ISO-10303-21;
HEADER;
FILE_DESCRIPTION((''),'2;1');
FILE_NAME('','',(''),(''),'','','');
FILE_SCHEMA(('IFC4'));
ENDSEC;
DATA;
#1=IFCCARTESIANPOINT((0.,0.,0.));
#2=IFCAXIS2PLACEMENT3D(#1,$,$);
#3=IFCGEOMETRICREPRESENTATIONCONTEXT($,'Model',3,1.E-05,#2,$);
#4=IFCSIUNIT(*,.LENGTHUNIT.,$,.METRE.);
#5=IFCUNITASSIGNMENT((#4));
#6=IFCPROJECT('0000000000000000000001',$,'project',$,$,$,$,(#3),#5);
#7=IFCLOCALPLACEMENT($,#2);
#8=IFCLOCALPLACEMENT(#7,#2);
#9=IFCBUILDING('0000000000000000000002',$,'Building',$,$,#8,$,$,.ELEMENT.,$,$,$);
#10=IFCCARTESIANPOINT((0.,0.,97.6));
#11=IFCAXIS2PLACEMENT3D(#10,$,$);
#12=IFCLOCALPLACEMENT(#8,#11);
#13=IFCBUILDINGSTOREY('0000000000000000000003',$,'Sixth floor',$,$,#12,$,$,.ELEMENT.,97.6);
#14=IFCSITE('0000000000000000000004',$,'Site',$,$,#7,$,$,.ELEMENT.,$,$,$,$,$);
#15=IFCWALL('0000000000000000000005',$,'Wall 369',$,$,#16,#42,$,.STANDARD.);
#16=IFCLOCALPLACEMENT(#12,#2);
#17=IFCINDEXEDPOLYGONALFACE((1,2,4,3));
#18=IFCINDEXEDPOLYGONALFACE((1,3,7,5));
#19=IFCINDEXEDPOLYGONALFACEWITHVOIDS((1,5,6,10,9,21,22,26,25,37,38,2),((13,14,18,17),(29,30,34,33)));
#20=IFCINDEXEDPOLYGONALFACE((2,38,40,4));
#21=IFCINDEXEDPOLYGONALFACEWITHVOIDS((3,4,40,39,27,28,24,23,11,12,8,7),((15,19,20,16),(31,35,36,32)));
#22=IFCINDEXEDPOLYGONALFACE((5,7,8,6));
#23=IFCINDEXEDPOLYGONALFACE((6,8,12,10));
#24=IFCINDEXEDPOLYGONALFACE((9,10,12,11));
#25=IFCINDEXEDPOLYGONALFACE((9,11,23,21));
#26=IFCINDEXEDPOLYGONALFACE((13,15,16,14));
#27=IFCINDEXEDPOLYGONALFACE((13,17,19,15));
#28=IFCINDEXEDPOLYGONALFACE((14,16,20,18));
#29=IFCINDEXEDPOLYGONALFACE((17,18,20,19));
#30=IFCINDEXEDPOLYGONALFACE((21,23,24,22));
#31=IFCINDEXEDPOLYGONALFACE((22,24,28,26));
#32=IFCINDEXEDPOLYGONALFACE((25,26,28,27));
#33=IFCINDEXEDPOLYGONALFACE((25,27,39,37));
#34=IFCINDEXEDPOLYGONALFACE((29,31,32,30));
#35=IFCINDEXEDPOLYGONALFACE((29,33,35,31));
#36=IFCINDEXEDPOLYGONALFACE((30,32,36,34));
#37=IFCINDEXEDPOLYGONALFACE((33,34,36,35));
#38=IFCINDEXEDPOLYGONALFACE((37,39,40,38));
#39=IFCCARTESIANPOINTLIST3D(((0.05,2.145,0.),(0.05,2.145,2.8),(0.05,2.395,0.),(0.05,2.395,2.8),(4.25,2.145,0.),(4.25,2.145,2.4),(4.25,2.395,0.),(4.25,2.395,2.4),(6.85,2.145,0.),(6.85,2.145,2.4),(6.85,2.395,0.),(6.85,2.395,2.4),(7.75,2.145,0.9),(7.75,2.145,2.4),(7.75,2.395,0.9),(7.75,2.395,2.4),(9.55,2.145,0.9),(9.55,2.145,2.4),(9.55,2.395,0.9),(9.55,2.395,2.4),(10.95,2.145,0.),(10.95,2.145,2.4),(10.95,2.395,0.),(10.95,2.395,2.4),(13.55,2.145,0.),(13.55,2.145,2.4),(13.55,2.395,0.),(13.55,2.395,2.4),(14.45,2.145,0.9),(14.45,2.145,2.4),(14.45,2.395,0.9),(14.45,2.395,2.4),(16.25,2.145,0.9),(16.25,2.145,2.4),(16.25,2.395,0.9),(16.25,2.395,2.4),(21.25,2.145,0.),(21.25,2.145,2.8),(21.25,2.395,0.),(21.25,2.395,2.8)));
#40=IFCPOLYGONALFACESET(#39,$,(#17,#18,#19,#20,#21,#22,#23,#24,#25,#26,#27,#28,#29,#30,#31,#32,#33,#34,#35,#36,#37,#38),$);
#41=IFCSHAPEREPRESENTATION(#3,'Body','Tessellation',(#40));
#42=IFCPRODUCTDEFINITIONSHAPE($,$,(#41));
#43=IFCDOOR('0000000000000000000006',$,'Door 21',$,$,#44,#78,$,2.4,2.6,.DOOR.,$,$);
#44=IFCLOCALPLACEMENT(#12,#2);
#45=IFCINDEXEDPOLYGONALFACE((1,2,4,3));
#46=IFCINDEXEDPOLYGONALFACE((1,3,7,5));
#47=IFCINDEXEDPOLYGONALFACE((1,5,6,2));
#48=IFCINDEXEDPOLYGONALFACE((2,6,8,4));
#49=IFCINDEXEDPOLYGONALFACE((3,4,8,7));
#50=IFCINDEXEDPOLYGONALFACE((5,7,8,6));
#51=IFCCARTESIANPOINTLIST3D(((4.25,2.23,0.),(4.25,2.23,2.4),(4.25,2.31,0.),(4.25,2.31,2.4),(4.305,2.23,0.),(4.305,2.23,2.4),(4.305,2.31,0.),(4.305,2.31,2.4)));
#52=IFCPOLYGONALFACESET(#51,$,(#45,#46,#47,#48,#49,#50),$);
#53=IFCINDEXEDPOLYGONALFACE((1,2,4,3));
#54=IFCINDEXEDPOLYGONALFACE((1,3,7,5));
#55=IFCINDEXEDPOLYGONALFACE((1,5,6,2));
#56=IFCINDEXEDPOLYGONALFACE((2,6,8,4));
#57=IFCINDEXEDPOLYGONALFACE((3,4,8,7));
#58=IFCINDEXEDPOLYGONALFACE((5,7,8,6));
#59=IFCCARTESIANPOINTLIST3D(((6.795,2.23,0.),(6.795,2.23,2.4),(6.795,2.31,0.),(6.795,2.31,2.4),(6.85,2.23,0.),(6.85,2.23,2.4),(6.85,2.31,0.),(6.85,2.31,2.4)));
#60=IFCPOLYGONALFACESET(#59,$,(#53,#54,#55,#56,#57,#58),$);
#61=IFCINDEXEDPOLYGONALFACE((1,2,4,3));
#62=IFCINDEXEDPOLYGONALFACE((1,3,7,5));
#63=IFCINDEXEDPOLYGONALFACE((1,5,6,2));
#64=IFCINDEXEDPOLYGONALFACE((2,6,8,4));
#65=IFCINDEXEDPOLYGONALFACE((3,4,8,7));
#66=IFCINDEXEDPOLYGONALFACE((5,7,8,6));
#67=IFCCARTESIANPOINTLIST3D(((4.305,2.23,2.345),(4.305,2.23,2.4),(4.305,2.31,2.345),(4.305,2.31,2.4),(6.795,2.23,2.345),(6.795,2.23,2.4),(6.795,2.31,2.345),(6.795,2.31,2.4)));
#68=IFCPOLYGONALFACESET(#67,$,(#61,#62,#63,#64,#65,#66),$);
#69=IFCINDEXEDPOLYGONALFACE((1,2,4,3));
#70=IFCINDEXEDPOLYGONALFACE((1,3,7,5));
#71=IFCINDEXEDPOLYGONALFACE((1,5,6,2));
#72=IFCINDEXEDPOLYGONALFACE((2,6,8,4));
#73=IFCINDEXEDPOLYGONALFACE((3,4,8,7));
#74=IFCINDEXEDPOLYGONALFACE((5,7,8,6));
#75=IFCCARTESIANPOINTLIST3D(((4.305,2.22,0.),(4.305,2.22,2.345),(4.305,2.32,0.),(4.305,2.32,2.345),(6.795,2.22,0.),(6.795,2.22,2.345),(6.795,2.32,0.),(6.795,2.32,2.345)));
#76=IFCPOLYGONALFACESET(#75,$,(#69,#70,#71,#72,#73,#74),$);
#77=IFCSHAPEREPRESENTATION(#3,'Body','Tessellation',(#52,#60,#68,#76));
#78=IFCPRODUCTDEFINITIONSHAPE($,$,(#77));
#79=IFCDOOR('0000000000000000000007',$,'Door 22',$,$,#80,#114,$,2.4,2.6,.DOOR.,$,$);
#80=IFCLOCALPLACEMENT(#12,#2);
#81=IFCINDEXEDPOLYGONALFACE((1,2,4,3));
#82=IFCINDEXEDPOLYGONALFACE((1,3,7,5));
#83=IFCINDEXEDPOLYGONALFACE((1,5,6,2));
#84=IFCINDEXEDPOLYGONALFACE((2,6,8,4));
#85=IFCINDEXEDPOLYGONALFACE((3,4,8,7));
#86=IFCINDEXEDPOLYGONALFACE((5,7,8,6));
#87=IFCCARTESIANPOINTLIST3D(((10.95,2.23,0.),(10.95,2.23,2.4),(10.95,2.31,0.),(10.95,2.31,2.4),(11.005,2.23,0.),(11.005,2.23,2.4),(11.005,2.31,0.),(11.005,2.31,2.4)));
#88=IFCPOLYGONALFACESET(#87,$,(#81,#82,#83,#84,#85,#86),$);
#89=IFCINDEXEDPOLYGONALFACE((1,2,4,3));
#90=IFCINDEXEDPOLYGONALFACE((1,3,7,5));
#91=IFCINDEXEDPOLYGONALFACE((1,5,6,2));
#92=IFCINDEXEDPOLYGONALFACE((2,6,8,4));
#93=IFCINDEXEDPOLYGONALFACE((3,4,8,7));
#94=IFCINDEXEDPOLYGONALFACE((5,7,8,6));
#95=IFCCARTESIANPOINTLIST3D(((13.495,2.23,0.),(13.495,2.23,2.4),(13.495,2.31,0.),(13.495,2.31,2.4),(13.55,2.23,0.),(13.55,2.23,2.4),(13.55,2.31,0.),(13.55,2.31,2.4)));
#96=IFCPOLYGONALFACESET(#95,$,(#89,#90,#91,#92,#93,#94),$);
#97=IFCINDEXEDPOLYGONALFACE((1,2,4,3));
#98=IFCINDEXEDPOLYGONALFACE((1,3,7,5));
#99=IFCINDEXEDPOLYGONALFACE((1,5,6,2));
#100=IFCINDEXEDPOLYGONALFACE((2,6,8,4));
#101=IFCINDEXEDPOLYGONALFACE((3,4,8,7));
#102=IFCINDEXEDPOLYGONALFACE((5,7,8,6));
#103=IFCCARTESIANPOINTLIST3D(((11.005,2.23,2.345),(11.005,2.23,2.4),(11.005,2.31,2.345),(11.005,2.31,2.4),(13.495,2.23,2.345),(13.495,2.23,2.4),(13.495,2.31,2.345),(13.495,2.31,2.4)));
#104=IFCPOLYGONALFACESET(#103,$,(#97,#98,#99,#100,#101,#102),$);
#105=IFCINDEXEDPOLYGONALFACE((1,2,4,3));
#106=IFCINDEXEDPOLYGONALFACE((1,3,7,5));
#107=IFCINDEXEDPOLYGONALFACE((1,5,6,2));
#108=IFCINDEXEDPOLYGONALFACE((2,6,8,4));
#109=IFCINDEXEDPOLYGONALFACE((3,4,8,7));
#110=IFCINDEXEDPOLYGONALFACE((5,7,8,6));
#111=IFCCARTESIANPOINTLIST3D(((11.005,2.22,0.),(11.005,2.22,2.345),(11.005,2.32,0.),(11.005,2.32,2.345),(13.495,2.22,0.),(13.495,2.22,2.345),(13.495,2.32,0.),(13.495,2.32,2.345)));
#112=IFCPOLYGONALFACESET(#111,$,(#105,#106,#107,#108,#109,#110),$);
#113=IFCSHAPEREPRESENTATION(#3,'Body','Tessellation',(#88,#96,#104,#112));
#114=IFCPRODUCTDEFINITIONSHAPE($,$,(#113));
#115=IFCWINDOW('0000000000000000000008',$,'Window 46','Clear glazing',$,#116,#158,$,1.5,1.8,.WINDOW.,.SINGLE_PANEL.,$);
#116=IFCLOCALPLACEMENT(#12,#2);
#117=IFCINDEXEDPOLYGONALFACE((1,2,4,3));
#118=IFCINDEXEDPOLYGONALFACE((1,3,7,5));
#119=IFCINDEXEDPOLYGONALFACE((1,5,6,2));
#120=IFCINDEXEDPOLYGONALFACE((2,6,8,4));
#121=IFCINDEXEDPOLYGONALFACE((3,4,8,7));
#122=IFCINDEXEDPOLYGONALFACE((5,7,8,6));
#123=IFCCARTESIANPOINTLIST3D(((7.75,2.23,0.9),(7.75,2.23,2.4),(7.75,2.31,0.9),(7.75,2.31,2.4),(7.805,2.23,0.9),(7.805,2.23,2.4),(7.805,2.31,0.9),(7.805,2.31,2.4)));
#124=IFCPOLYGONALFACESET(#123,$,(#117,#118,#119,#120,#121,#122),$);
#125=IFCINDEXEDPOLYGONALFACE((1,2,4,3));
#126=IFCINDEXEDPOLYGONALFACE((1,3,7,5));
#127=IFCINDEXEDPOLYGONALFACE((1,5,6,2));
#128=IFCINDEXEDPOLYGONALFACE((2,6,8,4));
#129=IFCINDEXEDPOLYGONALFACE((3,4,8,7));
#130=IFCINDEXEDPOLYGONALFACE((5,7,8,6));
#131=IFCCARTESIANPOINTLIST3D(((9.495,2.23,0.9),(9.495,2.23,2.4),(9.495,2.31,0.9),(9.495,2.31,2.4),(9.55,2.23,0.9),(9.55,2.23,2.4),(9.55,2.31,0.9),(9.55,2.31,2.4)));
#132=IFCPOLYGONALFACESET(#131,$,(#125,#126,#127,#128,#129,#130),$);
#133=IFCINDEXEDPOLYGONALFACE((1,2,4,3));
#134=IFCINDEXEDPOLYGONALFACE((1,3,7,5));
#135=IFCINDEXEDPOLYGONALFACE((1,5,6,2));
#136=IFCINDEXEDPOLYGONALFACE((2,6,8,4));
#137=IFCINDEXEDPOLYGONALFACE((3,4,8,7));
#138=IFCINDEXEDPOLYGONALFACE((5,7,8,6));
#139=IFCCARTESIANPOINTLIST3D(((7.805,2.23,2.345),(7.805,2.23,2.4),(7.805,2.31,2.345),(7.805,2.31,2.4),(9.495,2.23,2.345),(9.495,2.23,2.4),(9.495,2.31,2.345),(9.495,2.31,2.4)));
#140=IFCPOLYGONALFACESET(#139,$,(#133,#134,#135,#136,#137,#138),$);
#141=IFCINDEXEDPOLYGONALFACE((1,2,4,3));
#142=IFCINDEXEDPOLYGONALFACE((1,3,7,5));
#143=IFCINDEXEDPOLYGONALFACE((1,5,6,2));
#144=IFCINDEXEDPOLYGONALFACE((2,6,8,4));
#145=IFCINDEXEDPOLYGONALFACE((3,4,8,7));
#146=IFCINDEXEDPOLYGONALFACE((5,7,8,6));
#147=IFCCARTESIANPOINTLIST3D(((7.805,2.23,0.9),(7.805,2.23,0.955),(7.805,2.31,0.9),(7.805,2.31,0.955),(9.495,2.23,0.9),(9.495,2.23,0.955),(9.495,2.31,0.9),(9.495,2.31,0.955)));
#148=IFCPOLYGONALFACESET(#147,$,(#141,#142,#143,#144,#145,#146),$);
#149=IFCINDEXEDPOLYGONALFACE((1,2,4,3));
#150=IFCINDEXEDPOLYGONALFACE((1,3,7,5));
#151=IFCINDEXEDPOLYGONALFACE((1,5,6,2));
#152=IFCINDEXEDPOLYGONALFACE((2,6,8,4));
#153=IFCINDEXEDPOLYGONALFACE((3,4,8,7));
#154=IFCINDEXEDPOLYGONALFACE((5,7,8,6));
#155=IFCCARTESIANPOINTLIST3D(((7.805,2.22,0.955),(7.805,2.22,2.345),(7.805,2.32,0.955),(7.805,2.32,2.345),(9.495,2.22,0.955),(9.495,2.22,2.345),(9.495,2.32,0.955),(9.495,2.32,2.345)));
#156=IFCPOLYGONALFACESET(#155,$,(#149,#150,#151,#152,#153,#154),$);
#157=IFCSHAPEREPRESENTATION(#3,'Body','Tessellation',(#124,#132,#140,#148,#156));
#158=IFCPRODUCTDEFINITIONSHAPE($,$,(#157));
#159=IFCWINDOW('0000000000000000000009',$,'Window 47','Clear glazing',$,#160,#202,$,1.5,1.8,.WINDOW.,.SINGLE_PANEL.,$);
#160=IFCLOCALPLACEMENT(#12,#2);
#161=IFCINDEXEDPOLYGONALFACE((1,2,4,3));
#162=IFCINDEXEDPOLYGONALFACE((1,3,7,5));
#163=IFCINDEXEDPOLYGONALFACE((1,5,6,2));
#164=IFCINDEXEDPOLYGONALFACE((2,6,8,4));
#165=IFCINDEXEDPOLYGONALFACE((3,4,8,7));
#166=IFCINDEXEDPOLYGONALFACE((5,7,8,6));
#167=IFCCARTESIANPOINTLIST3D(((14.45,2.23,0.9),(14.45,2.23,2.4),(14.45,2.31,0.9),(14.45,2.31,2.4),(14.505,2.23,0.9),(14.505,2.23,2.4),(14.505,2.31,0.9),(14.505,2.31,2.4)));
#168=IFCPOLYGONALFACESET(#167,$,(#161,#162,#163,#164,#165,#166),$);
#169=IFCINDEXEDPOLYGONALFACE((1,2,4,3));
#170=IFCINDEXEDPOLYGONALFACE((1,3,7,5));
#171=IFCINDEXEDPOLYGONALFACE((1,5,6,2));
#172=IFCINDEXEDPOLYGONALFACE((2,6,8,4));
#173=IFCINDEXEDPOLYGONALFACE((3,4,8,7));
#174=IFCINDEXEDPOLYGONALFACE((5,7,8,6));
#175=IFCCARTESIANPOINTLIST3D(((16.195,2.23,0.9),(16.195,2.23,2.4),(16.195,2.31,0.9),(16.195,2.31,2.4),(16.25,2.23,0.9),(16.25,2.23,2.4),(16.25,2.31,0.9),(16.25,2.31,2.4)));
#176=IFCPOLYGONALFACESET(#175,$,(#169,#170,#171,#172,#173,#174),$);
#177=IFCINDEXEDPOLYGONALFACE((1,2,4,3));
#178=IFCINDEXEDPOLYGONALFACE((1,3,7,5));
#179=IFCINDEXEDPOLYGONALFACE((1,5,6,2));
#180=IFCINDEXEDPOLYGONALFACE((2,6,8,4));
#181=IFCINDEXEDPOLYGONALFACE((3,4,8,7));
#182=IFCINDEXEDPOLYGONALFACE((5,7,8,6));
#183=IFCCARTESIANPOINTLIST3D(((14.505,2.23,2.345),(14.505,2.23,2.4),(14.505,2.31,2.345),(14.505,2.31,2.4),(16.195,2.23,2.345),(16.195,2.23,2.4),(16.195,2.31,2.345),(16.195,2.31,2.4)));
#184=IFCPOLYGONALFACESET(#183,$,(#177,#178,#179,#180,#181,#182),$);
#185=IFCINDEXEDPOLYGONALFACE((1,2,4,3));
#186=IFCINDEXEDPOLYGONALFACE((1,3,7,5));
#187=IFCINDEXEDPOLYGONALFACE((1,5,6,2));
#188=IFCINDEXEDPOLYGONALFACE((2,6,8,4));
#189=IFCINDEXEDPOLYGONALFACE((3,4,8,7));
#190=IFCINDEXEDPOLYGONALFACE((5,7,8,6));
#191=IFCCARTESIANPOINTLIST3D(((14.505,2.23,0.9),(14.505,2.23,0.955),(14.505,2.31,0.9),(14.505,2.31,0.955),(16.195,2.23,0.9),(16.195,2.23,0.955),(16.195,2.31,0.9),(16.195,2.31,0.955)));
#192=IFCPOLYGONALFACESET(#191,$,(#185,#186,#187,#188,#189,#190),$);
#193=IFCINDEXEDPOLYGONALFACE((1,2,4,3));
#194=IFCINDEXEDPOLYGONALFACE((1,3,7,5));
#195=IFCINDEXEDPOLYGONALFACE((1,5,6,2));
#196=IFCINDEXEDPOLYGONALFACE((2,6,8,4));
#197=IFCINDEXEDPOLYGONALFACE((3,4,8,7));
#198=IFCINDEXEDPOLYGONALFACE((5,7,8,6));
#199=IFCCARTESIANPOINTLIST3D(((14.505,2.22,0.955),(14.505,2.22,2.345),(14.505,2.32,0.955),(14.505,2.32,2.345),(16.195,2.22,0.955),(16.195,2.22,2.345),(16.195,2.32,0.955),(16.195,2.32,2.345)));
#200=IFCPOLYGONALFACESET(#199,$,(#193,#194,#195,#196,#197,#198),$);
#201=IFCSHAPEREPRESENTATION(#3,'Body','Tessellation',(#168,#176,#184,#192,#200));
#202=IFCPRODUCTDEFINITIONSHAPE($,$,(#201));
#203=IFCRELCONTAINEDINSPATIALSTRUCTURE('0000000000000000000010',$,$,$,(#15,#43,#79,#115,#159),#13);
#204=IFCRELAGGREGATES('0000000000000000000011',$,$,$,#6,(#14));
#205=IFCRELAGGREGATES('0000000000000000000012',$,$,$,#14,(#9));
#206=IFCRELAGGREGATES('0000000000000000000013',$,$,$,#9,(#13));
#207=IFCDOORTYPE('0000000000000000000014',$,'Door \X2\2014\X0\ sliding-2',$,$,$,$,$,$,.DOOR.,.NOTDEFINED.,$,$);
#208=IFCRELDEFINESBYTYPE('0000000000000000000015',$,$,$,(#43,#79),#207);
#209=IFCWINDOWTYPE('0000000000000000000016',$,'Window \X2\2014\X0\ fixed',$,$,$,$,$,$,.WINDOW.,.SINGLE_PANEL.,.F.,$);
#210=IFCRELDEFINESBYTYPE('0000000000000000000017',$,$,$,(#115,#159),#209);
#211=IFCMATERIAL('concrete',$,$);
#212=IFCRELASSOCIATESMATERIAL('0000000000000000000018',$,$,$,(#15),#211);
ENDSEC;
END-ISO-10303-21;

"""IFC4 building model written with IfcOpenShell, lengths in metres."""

from ifc_helpers import new_model, si_unit, frame, frame_2d, origin, place, context, project, spatial, rectangle, extrude, material, type_object, element, fill, save


model = new_model("IFC4")

# Units and contexts
model_context = context("Model", 3, precision=1e-05, world=origin())
ifc_project = project(units=[si_unit("LENGTHUNIT", "METRE")], contexts=[model_context])

# Site, building, storey
site_placement = place(None, origin())
site = spatial("IfcSite", under=ifc_project, at=site_placement, Name="Site", CompositionType="ELEMENT")
building_placement = place(site_placement, origin())
building = spatial("IfcBuilding", under=site, at=building_placement, Name="Building", CompositionType="ELEMENT")
storey_placement = place(building_placement, frame((0.0, 0.0, 97.6)))
storey = spatial("IfcBuildingStorey", under=building, at=storey_placement, Name="Sixth floor", CompositionType="ELEMENT", Elevation=97.6)

# Shared definitions
ifc_material = material(Name="concrete")

# Wall, openings, doors, windows
wall_1_placement = place(storey_placement, frame((0.05, 2.27, 0.0), z_axis=(0.0, 0.0, 1.0), x_axis=(1.0, 0.0, 0.0)))
wall_1 = element("IfcWall", 1, at=wall_1_placement, inside=storey, material=ifc_material, Name="Wall 369", PredefinedType="STANDARD", context=model_context, shape_type="SweptSolid", body=[
    extrude(rectangle(XDim=21.2, YDim=0.25, at=frame_2d((10.6, 0.0))), origin(), (0.0, 0.0, 1.0), 2.8),
])
opening_1_placement = place(storey_placement, frame((4.25, 2.27, 0.0), z_axis=(0.0, 0.0, 1.0), x_axis=(1.0, 0.0, 0.0)))
opening_1 = element("IfcOpeningElement", 2, at=opening_1_placement, cuts=wall_1, PredefinedType="OPENING", context=model_context, shape_type="SweptSolid", body=[
    extrude(rectangle(XDim=2.6, YDim=0.31, at=frame_2d((1.3, 0.0))), origin(), (0.0, 0.0, 1.0), 2.4),
])
opening_2_placement = place(storey_placement, frame((7.75, 2.27, 0.9), z_axis=(0.0, 0.0, 1.0), x_axis=(1.0, 0.0, 0.0)))
opening_2 = element("IfcOpeningElement", 3, at=opening_2_placement, cuts=wall_1, PredefinedType="OPENING", context=model_context, shape_type="SweptSolid", body=[
    extrude(rectangle(XDim=1.8, YDim=0.31, at=frame_2d((0.9, 0.0))), origin(), (0.0, 0.0, 1.0), 1.5),
])
opening_3_placement = place(storey_placement, frame((10.95, 2.27, 0.0), z_axis=(0.0, 0.0, 1.0), x_axis=(1.0, 0.0, 0.0)))
opening_3 = element("IfcOpeningElement", 4, at=opening_3_placement, cuts=wall_1, PredefinedType="OPENING", context=model_context, shape_type="SweptSolid", body=[
    extrude(rectangle(XDim=2.6, YDim=0.31, at=frame_2d((1.3, 0.0))), origin(), (0.0, 0.0, 1.0), 2.4),
])
opening_4_placement = place(storey_placement, frame((14.45, 2.27, 0.9), z_axis=(0.0, 0.0, 1.0), x_axis=(1.0, 0.0, 0.0)))
opening_4 = element("IfcOpeningElement", 5, at=opening_4_placement, cuts=wall_1, PredefinedType="OPENING", context=model_context, shape_type="SweptSolid", body=[
    extrude(rectangle(XDim=1.8, YDim=0.31, at=frame_2d((0.9, 0.0))), origin(), (0.0, 0.0, 1.0), 1.5),
])
door_type = type_object("IfcDoorType", Name="Door — sliding-2", PredefinedType="DOOR")
door_1_placement = place(storey_placement, frame((4.25, 2.27, 0.0), z_axis=(0.0, 0.0, 1.0), x_axis=(1.0, 0.0, 0.0)))
door_1 = element("IfcDoor", 6, at=door_1_placement, inside=storey, type_object=door_type, Name="Door 21", OverallHeight=2.4, OverallWidth=2.6, PredefinedType="DOOR", context=model_context, shape_type="SweptSolid", body=[
    extrude(rectangle(XDim=0.055, YDim=0.08, at=frame_2d((0.0275, 0.0))), origin(), (0.0, 0.0, 1.0), 2.4),
    extrude(rectangle(XDim=0.055, YDim=0.08, at=frame_2d((2.5725, 0.0))), origin(), (0.0, 0.0, 1.0), 2.4),
    extrude(rectangle(XDim=2.49, YDim=0.08, at=frame_2d((1.3, 0.0))), frame((0.0, 0.0, 2.345)), (0.0, 0.0, 1.0), 0.055),
    extrude(rectangle(XDim=2.49, YDim=0.1, at=frame_2d((1.3, 0.0))), origin(), (0.0, 0.0, 1.0), 2.345),
])
fill(opening_1, door_1)
door_2_placement = place(storey_placement, frame((10.95, 2.27, 0.0), z_axis=(0.0, 0.0, 1.0), x_axis=(1.0, 0.0, 0.0)))
door_2 = element("IfcDoor", 7, at=door_2_placement, inside=storey, type_object=door_type, Name="Door 22", OverallHeight=2.4, OverallWidth=2.6, PredefinedType="DOOR", context=model_context, shape_type="SweptSolid", body=[
    extrude(rectangle(XDim=0.055, YDim=0.08, at=frame_2d((0.0275, 0.0))), origin(), (0.0, 0.0, 1.0), 2.4),
    extrude(rectangle(XDim=0.055, YDim=0.08, at=frame_2d((2.5725, 0.0))), origin(), (0.0, 0.0, 1.0), 2.4),
    extrude(rectangle(XDim=2.49, YDim=0.08, at=frame_2d((1.3, 0.0))), frame((0.0, 0.0, 2.345)), (0.0, 0.0, 1.0), 0.055),
    extrude(rectangle(XDim=2.49, YDim=0.1, at=frame_2d((1.3, 0.0))), origin(), (0.0, 0.0, 1.0), 2.345),
])
fill(opening_3, door_2)
window_type = type_object("IfcWindowType", Name="Window — fixed", ParameterTakesPrecedence=False, PartitioningType="SINGLE_PANEL", PredefinedType="WINDOW")
window_1_placement = place(storey_placement, frame((7.75, 2.27, 0.9), z_axis=(0.0, 0.0, 1.0), x_axis=(1.0, 0.0, 0.0)))
window_1 = element("IfcWindow", 8, at=window_1_placement, inside=storey, type_object=window_type, Name="Window 46", Description="Clear glazing", OverallHeight=1.5, OverallWidth=1.8, PartitioningType="SINGLE_PANEL", PredefinedType="WINDOW", context=model_context, shape_type="SweptSolid", body=[
    extrude(rectangle(XDim=0.055, YDim=0.08, at=frame_2d((0.0275, 0.0))), origin(), (0.0, 0.0, 1.0), 1.5),
    extrude(rectangle(XDim=0.055, YDim=0.08, at=frame_2d((1.7725, 0.0))), origin(), (0.0, 0.0, 1.0), 1.5),
    extrude(rectangle(XDim=1.69, YDim=0.08, at=frame_2d((0.9, 0.0))), frame((0.0, 0.0, 1.445)), (0.0, 0.0, 1.0), 0.055),
    extrude(rectangle(XDim=1.69, YDim=0.08, at=frame_2d((0.9, 0.0))), origin(), (0.0, 0.0, 1.0), 0.055),
    extrude(rectangle(XDim=1.69, YDim=0.1, at=frame_2d((0.9, 0.0))), frame((0.0, 0.0, 0.055)), (0.0, 0.0, 1.0), 1.39),
])
fill(opening_2, window_1)
window_2_placement = place(storey_placement, frame((14.45, 2.27, 0.9), z_axis=(0.0, 0.0, 1.0), x_axis=(1.0, 0.0, 0.0)))
window_2 = element("IfcWindow", 9, at=window_2_placement, inside=storey, type_object=window_type, Name="Window 47", Description="Clear glazing", OverallHeight=1.5, OverallWidth=1.8, PartitioningType="SINGLE_PANEL", PredefinedType="WINDOW", context=model_context, shape_type="SweptSolid", body=[
    extrude(rectangle(XDim=0.055, YDim=0.08, at=frame_2d((0.0275, 0.0))), origin(), (0.0, 0.0, 1.0), 1.5),
    extrude(rectangle(XDim=0.055, YDim=0.08, at=frame_2d((1.7725, 0.0))), origin(), (0.0, 0.0, 1.0), 1.5),
    extrude(rectangle(XDim=1.69, YDim=0.08, at=frame_2d((0.9, 0.0))), frame((0.0, 0.0, 1.445)), (0.0, 0.0, 1.0), 0.055),
    extrude(rectangle(XDim=1.69, YDim=0.08, at=frame_2d((0.9, 0.0))), origin(), (0.0, 0.0, 1.0), 0.055),
    extrude(rectangle(XDim=1.69, YDim=0.1, at=frame_2d((0.9, 0.0))), frame((0.0, 0.0, 0.055)), (0.0, 0.0, 1.0), 1.39),
])
fill(opening_4, window_2)

save(model, "model.ifc")
